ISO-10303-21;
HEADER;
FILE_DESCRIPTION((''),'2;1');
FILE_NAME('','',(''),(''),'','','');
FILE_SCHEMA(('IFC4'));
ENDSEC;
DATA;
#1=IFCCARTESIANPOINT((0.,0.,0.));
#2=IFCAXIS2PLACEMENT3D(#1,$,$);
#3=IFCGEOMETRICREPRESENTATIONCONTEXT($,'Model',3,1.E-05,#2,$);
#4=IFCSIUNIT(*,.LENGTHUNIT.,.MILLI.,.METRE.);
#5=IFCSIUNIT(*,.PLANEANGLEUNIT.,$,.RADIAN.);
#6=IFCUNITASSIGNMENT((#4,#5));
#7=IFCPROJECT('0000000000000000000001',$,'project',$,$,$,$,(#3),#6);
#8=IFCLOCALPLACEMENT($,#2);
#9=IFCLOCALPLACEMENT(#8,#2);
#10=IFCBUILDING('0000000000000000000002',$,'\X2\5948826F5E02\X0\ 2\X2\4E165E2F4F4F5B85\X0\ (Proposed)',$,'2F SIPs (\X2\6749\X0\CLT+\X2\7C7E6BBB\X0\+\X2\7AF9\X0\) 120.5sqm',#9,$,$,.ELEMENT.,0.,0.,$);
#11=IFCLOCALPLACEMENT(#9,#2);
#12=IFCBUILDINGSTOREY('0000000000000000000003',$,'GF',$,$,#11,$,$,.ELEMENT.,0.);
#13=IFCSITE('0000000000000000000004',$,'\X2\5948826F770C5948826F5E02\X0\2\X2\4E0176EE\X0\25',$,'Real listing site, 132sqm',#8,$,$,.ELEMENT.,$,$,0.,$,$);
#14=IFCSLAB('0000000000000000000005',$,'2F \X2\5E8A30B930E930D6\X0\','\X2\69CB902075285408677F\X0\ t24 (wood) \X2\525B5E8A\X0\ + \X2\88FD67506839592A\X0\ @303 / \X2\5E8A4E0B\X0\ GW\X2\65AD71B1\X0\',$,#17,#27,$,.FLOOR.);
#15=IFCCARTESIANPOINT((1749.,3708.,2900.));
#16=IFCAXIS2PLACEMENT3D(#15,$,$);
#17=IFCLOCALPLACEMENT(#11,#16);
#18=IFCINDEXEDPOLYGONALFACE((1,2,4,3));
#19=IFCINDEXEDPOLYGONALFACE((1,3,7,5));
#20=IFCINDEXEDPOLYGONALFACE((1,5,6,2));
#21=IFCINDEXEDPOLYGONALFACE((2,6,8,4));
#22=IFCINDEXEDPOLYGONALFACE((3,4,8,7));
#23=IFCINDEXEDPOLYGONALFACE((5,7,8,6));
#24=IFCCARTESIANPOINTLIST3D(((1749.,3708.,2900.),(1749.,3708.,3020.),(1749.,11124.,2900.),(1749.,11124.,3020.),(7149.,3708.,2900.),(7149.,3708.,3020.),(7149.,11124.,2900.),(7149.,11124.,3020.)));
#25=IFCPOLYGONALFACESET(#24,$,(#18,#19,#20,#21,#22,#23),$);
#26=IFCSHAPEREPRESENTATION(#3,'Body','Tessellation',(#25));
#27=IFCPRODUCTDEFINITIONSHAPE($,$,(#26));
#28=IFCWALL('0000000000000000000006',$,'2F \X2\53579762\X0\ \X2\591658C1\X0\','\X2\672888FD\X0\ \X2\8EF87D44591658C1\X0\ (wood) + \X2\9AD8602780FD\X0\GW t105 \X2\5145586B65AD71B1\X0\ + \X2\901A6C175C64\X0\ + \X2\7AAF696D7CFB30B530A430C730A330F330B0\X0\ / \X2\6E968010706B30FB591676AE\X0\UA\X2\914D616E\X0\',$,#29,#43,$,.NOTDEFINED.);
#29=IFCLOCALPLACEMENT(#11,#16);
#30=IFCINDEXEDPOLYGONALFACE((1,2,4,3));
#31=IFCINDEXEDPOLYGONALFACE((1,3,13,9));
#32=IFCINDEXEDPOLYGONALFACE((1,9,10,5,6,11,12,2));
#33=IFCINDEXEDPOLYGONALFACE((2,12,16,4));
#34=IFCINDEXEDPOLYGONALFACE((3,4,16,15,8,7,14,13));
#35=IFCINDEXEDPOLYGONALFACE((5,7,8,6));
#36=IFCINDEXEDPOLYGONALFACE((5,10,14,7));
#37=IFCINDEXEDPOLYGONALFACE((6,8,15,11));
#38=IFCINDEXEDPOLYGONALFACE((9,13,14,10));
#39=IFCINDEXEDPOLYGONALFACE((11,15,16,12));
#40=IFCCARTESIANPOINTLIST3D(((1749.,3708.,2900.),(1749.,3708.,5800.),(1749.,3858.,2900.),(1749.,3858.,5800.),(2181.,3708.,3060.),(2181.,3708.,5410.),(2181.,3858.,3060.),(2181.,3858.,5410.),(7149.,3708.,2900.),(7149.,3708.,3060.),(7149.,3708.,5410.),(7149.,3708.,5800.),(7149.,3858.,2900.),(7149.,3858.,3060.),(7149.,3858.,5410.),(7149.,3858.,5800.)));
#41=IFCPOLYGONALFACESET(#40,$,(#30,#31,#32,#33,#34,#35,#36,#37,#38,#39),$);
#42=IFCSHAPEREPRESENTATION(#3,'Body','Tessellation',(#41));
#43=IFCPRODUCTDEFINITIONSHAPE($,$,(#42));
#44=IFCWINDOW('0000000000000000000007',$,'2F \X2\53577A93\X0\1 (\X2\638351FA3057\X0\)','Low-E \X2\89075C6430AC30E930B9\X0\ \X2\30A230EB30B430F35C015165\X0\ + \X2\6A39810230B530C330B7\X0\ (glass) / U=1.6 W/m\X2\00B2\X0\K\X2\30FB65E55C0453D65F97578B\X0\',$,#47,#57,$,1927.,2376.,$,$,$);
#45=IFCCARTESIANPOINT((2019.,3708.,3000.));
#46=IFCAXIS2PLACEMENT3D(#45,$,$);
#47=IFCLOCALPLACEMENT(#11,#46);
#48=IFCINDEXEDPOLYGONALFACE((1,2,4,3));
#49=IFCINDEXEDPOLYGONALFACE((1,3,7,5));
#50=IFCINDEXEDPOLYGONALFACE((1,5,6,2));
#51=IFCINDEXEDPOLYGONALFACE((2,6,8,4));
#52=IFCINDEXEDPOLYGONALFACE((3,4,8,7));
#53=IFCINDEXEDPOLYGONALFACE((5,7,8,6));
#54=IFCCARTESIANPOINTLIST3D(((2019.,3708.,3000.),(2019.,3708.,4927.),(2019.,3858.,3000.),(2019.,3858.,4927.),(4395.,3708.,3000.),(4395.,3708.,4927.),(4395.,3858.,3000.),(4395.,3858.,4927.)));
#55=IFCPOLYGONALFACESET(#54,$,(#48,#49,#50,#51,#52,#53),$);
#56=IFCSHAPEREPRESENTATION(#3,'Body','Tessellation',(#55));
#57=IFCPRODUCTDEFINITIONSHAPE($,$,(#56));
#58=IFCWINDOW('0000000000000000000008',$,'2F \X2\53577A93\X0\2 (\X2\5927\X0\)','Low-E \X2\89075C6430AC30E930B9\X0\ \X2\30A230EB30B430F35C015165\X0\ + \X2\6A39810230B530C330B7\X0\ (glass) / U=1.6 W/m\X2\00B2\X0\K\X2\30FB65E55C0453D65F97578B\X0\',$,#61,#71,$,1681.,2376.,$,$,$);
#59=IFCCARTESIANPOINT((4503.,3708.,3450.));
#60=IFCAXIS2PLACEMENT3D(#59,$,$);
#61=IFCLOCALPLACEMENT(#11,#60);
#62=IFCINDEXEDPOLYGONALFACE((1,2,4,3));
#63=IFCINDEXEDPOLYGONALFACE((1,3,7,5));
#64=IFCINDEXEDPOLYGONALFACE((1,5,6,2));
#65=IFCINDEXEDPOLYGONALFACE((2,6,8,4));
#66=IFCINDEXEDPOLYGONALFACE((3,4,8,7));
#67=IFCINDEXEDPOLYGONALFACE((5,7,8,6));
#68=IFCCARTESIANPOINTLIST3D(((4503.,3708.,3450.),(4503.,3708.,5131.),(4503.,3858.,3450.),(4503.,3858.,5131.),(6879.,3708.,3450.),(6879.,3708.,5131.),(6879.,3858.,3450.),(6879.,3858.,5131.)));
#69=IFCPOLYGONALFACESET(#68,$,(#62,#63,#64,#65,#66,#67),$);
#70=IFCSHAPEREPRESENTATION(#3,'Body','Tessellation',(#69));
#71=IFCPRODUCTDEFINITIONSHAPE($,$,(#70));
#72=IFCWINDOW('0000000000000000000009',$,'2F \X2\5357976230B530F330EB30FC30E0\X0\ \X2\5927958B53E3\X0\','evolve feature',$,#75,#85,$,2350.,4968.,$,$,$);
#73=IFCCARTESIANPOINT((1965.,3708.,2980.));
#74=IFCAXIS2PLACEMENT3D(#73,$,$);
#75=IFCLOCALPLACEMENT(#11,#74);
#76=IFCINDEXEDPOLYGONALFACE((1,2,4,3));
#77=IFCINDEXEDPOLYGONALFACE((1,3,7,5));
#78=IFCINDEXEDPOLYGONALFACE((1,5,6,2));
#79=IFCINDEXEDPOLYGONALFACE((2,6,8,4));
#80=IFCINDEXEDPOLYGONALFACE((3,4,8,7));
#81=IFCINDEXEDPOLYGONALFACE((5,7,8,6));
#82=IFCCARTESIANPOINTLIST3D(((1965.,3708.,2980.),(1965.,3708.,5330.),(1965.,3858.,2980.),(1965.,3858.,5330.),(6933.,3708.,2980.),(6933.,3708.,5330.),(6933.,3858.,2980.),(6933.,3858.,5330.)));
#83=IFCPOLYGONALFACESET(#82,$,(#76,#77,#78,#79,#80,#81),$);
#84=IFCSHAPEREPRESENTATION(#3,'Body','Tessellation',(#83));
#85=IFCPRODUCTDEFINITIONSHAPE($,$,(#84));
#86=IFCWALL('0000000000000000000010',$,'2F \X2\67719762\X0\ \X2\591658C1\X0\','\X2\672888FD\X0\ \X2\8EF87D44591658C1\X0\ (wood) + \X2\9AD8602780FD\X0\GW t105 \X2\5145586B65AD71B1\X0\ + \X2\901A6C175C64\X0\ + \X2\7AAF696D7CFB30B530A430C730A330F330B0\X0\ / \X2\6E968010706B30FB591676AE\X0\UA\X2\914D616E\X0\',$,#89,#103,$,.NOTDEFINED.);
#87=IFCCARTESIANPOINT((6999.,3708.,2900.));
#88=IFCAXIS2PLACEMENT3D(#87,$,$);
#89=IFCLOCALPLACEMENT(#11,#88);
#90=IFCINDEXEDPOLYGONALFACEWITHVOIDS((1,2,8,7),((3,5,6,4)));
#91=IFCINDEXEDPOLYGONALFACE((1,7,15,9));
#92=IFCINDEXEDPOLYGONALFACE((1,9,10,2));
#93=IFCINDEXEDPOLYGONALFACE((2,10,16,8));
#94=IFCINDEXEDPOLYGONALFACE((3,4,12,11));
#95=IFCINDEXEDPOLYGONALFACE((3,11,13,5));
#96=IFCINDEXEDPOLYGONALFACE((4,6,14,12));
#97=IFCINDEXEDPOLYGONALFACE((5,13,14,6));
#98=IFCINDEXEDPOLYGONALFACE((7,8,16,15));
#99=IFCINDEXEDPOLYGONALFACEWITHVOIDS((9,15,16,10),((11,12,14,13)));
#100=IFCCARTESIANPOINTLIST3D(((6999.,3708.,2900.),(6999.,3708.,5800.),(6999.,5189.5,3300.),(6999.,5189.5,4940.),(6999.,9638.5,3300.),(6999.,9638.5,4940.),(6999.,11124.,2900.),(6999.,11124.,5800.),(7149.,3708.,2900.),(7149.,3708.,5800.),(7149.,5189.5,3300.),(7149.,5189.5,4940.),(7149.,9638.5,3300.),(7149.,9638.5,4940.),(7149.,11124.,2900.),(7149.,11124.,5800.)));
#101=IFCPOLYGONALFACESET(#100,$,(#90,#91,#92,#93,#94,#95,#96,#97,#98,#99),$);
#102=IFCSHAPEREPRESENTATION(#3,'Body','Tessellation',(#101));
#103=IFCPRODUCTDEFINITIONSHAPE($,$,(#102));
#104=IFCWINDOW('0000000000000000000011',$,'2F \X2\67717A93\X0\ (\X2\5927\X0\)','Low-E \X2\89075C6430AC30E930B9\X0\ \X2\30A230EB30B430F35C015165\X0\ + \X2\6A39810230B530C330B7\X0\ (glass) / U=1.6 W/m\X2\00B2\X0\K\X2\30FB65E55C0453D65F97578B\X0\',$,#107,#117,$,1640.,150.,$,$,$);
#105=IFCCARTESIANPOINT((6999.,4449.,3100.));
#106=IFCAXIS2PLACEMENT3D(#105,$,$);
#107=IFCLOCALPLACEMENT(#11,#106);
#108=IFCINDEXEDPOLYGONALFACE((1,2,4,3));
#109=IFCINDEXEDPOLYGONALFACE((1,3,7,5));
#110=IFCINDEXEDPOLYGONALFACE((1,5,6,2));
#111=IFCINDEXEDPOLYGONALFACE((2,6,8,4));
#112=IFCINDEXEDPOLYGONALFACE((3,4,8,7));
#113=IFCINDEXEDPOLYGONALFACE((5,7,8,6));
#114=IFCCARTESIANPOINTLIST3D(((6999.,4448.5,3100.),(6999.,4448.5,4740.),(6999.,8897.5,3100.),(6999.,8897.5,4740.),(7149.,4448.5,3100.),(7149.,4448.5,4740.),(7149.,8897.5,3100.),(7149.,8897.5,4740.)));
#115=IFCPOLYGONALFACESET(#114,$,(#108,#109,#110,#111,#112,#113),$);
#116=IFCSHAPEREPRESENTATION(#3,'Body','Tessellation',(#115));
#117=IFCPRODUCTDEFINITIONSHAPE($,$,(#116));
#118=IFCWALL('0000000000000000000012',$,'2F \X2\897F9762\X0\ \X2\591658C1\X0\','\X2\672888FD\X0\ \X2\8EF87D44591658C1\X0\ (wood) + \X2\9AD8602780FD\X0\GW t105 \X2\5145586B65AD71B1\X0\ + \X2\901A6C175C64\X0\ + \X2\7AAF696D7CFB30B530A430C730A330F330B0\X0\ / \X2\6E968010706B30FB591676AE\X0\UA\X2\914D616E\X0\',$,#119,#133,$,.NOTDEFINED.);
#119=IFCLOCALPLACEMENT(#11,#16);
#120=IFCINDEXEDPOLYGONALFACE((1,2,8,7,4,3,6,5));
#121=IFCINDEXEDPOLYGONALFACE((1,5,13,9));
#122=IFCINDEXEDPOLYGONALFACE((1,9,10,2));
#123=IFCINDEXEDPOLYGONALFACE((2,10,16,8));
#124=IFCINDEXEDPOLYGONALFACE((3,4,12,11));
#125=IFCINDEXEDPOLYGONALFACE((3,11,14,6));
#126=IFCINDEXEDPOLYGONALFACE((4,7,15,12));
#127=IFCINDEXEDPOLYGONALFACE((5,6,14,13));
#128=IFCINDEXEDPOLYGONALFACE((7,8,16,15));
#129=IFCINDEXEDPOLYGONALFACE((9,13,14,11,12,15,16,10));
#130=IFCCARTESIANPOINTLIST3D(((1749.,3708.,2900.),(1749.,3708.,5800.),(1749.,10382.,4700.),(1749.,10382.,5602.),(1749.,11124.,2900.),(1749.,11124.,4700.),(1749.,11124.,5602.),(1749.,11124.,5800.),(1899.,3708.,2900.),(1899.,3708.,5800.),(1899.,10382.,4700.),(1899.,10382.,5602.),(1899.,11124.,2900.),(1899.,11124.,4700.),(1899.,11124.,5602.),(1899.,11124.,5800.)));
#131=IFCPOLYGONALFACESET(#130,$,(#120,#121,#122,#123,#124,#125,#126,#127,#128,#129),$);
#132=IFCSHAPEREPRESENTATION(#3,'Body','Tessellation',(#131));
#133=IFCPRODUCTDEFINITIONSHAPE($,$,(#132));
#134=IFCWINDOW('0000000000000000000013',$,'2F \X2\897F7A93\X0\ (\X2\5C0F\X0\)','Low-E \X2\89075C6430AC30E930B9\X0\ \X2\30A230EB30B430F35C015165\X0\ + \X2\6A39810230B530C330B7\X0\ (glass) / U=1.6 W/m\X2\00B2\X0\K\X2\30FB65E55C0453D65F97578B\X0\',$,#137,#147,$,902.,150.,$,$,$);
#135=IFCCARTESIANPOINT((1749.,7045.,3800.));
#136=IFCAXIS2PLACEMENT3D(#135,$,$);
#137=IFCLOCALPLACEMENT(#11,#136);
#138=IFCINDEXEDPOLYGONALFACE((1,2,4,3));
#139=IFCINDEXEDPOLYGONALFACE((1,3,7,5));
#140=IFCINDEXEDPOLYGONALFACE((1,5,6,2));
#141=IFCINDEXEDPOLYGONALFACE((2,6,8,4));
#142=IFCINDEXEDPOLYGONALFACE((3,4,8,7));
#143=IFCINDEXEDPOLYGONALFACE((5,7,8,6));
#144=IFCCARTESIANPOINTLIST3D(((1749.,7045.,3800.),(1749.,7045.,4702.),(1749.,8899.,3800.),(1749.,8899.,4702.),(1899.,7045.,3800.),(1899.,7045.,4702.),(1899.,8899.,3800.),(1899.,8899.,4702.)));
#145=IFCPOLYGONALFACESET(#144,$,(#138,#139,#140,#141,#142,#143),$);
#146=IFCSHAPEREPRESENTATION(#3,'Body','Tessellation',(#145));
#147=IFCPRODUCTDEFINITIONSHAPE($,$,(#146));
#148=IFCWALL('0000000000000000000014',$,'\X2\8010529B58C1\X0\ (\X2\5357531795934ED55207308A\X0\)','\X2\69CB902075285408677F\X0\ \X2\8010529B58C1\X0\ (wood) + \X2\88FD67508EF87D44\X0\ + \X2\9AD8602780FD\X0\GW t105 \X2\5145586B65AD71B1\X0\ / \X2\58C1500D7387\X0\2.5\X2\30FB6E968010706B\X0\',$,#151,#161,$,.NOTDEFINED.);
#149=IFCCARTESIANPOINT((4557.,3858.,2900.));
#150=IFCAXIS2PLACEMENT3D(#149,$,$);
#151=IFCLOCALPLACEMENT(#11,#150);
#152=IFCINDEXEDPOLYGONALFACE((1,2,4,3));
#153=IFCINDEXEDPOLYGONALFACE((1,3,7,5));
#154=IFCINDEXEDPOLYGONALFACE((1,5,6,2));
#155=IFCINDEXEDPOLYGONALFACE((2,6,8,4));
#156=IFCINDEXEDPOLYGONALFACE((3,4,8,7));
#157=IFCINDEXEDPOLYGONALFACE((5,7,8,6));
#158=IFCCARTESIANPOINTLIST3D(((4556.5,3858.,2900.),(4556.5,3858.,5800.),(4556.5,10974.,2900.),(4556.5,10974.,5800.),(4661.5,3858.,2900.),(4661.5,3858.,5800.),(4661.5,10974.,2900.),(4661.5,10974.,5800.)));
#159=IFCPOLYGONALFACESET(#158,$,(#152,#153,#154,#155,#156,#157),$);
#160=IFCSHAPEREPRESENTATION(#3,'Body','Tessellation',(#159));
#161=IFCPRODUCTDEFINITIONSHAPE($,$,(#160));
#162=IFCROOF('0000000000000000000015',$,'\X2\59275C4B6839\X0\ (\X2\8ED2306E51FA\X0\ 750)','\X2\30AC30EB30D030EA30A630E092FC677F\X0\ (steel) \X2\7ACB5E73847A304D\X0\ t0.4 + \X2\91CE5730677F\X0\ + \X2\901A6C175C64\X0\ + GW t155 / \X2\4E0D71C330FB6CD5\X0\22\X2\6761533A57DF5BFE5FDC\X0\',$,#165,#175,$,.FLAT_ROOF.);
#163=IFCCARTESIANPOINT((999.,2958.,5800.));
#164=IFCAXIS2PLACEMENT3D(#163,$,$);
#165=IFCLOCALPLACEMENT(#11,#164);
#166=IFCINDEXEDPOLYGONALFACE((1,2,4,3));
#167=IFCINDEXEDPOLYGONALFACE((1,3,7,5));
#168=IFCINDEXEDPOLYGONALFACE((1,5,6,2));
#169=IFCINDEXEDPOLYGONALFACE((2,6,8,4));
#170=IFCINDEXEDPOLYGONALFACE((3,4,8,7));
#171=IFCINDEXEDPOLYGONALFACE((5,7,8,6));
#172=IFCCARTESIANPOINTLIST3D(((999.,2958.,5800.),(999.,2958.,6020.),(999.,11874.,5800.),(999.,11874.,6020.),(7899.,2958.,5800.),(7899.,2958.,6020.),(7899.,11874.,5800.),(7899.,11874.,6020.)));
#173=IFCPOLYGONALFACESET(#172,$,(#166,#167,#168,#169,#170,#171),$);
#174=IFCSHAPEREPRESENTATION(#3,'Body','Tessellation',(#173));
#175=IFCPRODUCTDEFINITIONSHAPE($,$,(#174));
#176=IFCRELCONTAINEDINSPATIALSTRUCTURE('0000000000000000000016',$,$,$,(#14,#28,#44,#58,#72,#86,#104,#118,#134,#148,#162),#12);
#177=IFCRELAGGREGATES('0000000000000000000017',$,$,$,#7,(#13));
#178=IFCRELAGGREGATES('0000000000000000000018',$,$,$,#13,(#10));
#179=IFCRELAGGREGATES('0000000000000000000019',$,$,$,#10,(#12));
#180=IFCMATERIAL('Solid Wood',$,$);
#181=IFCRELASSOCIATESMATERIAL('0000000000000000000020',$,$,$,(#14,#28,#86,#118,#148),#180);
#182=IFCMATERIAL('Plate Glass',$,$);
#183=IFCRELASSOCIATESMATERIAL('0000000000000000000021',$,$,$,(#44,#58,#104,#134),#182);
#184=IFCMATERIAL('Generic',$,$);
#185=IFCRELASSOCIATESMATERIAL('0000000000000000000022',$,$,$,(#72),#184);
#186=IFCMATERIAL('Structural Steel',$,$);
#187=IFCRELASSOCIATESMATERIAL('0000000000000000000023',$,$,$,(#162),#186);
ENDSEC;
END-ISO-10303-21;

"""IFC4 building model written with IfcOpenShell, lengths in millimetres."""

from ifc_helpers import new_model, si_unit, frame, frame_2d, origin, place, context, project, spatial, rectangle, extrude, material, element, fill, save


model = new_model("IFC4")

# Units and contexts
model_context = context("Model", 3, precision=1e-05, world=origin())
ifc_project = project(units=[si_unit("LENGTHUNIT", "METRE", prefix="MILLI"), si_unit("PLANEANGLEUNIT", "RADIAN")], contexts=[model_context])

# Site, building, storey
site_placement = place(None, origin())
site = spatial("IfcSite", under=ifc_project, at=site_placement, Name="奈良県奈良市2丁目25", ObjectType="Real listing site, 132sqm", CompositionType="ELEMENT", RefElevation=0.0)
building_placement = place(site_placement, origin())
building = spatial("IfcBuilding", under=site, at=building_placement, Name="奈良市 2世帯住宅 (Proposed)", ObjectType="2F SIPs (杉CLT+籾殻+竹) 120.5sqm", CompositionType="ELEMENT", ElevationOfRefHeight=0.0, ElevationOfTerrain=0.0)
storey_placement = place(building_placement, origin())
storey = spatial("IfcBuildingStorey", under=building, at=storey_placement, Name="GF", CompositionType="ELEMENT", Elevation=0.0)

# Slab
ifc_material_1 = material(Name="Solid Wood")
slab_placement = place(storey_placement, frame((1749.0, 3708.0, 2900.0)))
element("IfcSlab", 1, at=slab_placement, inside=storey, material=ifc_material_1, Name="2F 床スラブ", Description="構造用合板 t24 (wood) 剛床 + 製材根太 @303 / 床下 GW断熱", PredefinedType="FLOOR", context=model_context, shape_type="SweptSolid", body=[
    extrude(rectangle(XDim=5400.0, YDim=7416.0, at=frame_2d((2700.0, 3708.0))), frame((1749.0, 3708.0, 2900.0)), (0.0, 0.0, 1.0), 120.0),
])

# Wall, openings, windows
wall_1_placement = place(storey_placement, frame((1749.0, 3708.0, 2900.0)))
wall_1 = element("IfcWall", 2, at=wall_1_placement, inside=storey, material=ifc_material_1, Name="2F 南面 外壁", Description="木製 軸組外壁 (wood) + 高性能GW t105 充填断熱 + 通気層 + 窯業系サイディング / 準耐火・外皮UA配慮", PredefinedType="NOTDEFINED", context=model_context, shape_type="SweptSolid", body=[
    extrude(rectangle(XDim=5400.0, YDim=150.0, at=frame_2d((2700.0, 75.0))), frame((1749.0, 3708.0, 2900.0)), (0.0, 0.0, 1.0), 2900.0),
])
opening_1_placement = place(storey_placement, frame((2019.0, 3708.0, 3000.0)))
opening_1 = element("IfcOpeningElement", 3, at=opening_1_placement, cuts=wall_1, PredefinedType="NOTDEFINED", context=model_context, shape_type="SweptSolid", body=[
    extrude(rectangle(XDim=2376.0, YDim=150.0, at=frame_2d((1188.0, 75.0))), frame((2019.0, 3708.0, 3000.0)), (0.0, 0.0, 1.0), 1927.0),
])
opening_2_placement = place(storey_placement, frame((4503.0, 3708.0, 3450.0)))
opening_2 = element("IfcOpeningElement", 4, at=opening_2_placement, cuts=wall_1, PredefinedType="NOTDEFINED", context=model_context, shape_type="SweptSolid", body=[
    extrude(rectangle(XDim=2376.0, YDim=150.0, at=frame_2d((1188.0, 75.0))), frame((4503.0, 3708.0, 3450.0)), (0.0, 0.0, 1.0), 1681.0),
])
opening_3_placement = place(storey_placement, frame((1965.0, 3708.0, 2980.0)))
opening_3 = element("IfcOpeningElement", 5, at=opening_3_placement, cuts=wall_1, PredefinedType="NOTDEFINED", context=model_context, shape_type="SweptSolid", body=[
    extrude(rectangle(XDim=4968.0, YDim=150.0, at=frame_2d((2484.0, 75.0))), frame((1965.0, 3708.0, 2980.0)), (0.0, 0.0, 1.0), 2350.0),
])
ifc_material_2 = material(Name="Plate Glass")
window_1_placement = place(storey_placement, frame((2019.0, 3708.0, 3000.0)))
window_1 = element("IfcWindow", 6, at=window_1_placement, inside=storey, material=ifc_material_2, Name="2F 南窓1 (掃出し)", Description="Low-E 複層ガラス アルゴン封入 + 樹脂サッシ (glass) / U=1.6 W/m²K・日射取得型", OverallHeight=1927.0, OverallWidth=2376.0, context=model_context, shape_type="SweptSolid", body=[
    extrude(rectangle(XDim=2376.0, YDim=150.0, at=frame_2d((1188.0, 75.0))), frame((2019.0, 3708.0, 3000.0)), (0.0, 0.0, 1.0), 1927.0),
])
fill(opening_1, window_1)
window_2_placement = place(storey_placement, frame((4503.0, 3708.0, 3450.0)))
window_2 = element("IfcWindow", 7, at=window_2_placement, inside=storey, material=ifc_material_2, Name="2F 南窓2 (大)", Description="Low-E 複層ガラス アルゴン封入 + 樹脂サッシ (glass) / U=1.6 W/m²K・日射取得型", OverallHeight=1681.0, OverallWidth=2376.0, context=model_context, shape_type="SweptSolid", body=[
    extrude(rectangle(XDim=2376.0, YDim=150.0, at=frame_2d((1188.0, 75.0))), frame((4503.0, 3708.0, 3450.0)), (0.0, 0.0, 1.0), 1681.0),
])
fill(opening_2, window_2)
ifc_material_3 = material(Name="Generic")
window_3_placement = place(storey_placement, frame((1965.0, 3708.0, 2980.0)))
window_3 = element("IfcWindow", 8, at=window_3_placement, inside=storey, material=ifc_material_3, Name="2F 南面サンルーム 大開口", Description="evolve feature", OverallHeight=2350.0, OverallWidth=4968.0, context=model_context, shape_type="SweptSolid", body=[
    extrude(rectangle(XDim=4968.0, YDim=150.0, at=frame_2d((2484.0, 75.0))), frame((1965.0, 3708.0, 2980.0)), (0.0, 0.0, 1.0), 2350.0),
])
fill(opening_3, window_3)

# Walls, openings, windows
wall_2_placement = place(storey_placement, frame((6999.0, 3708.0, 2900.0)))
wall_2 = element("IfcWall", 9, at=wall_2_placement, inside=storey, material=ifc_material_1, Name="2F 東面 外壁", Description="木製 軸組外壁 (wood) + 高性能GW t105 充填断熱 + 通気層 + 窯業系サイディング / 準耐火・外皮UA配慮", PredefinedType="NOTDEFINED", context=model_context, shape_type="SweptSolid", body=[
    extrude(rectangle(XDim=150.0, YDim=7416.0, at=frame_2d((75.0, 3708.0))), frame((6999.0, 3708.0, 2900.0)), (0.0, 0.0, 1.0), 2900.0),
])
opening_4_placement = place(storey_placement, frame((6999.0, 4449.0, 3100.0)))
opening_4 = element("IfcOpeningElement", 10, at=opening_4_placement, cuts=wall_2, PredefinedType="NOTDEFINED", context=model_context, shape_type="SweptSolid", body=[
    extrude(rectangle(XDim=150.0, YDim=4449.0, at=frame_2d((75.0, 2224.0))), frame((6999.0, 4449.0, 3100.0)), (0.0, 0.0, 1.0), 1640.0),
])
window_4_placement = place(storey_placement, frame((6999.0, 4449.0, 3100.0)))
window_4 = element("IfcWindow", 11, at=window_4_placement, inside=storey, material=ifc_material_2, Name="2F 東窓 (大)", Description="Low-E 複層ガラス アルゴン封入 + 樹脂サッシ (glass) / U=1.6 W/m²K・日射取得型", OverallHeight=1640.0, OverallWidth=150.0, context=model_context, shape_type="SweptSolid", body=[
    extrude(rectangle(XDim=150.0, YDim=4449.0, at=frame_2d((75.0, 2224.0))), frame((6999.0, 4449.0, 3100.0)), (0.0, 0.0, 1.0), 1640.0),
])
fill(opening_4, window_4)
wall_3_placement = place(storey_placement, frame((1749.0, 3708.0, 2900.0)))
wall_3 = element("IfcWall", 12, at=wall_3_placement, inside=storey, material=ifc_material_1, Name="2F 西面 外壁", Description="木製 軸組外壁 (wood) + 高性能GW t105 充填断熱 + 通気層 + 窯業系サイディング / 準耐火・外皮UA配慮", PredefinedType="NOTDEFINED", context=model_context, shape_type="SweptSolid", body=[
    extrude(rectangle(XDim=150.0, YDim=7416.0, at=frame_2d((75.0, 3708.0))), frame((1749.0, 3708.0, 2900.0)), (0.0, 0.0, 1.0), 2900.0),
])
opening_5_placement = place(storey_placement, frame((1749.0, 7045.0, 3800.0)))
opening_5 = element("IfcOpeningElement", 13, at=opening_5_placement, cuts=wall_3, PredefinedType="NOTDEFINED", context=model_context, shape_type="SweptSolid", body=[
    extrude(rectangle(XDim=150.0, YDim=1854.0, at=frame_2d((75.0, 927.0))), frame((1749.0, 7045.0, 3800.0)), (0.0, 0.0, 1.0), 902.0),
])
window_5_placement = place(storey_placement, frame((1749.0, 7045.0, 3800.0)))
window_5 = element("IfcWindow", 14, at=window_5_placement, inside=storey, material=ifc_material_2, Name="2F 西窓 (小)", Description="Low-E 複層ガラス アルゴン封入 + 樹脂サッシ (glass) / U=1.6 W/m²K・日射取得型", OverallHeight=902.0, OverallWidth=150.0, context=model_context, shape_type="SweptSolid", body=[
    extrude(rectangle(XDim=150.0, YDim=1854.0, at=frame_2d((75.0, 927.0))), frame((1749.0, 7045.0, 3800.0)), (0.0, 0.0, 1.0), 902.0),
])
fill(opening_5, window_5)

# Wall
wall_4_placement = place(storey_placement, frame((4557.0, 3858.0, 2900.0)))
element("IfcWall", 15, at=wall_4_placement, inside=storey, material=ifc_material_1, Name="耐力壁 (南北間仕切り)", Description="構造用合板 耐力壁 (wood) + 製材軸組 + 高性能GW t105 充填断熱 / 壁倍率2.5・準耐火", PredefinedType="NOTDEFINED", context=model_context, shape_type="SweptSolid", body=[
    extrude(rectangle(XDim=105.0, YDim=7116.0, at=frame_2d((52.0, 3558.0))), frame((4557.0, 3858.0, 2900.0)), (0.0, 0.0, 1.0), 2900.0),
])

# Roof
ifc_material_4 = material(Name="Structural Steel")
roof_1_placement = place(storey_placement, frame((999.0, 2958.0, 5800.0)))
element("IfcRoof", 16, at=roof_1_placement, inside=storey, material=ifc_material_4, Name="大屋根 (軒の出 750)", Description="ガルバリウム鋼板 (steel) 立平葺き t0.4 + 野地板 + 通気層 + GW t155 / 不燃・法22条区域対応", PredefinedType="FLAT_ROOF", context=model_context, shape_type="SweptSolid", body=[
    extrude(rectangle(XDim=6900.0, YDim=8916.0, at=frame_2d((3450.0, 4458.0))), frame((999.0, 2958.0, 5800.0)), (0.0, 0.0, 1.0), 220.0),
])

save(model, "model.ifc")
